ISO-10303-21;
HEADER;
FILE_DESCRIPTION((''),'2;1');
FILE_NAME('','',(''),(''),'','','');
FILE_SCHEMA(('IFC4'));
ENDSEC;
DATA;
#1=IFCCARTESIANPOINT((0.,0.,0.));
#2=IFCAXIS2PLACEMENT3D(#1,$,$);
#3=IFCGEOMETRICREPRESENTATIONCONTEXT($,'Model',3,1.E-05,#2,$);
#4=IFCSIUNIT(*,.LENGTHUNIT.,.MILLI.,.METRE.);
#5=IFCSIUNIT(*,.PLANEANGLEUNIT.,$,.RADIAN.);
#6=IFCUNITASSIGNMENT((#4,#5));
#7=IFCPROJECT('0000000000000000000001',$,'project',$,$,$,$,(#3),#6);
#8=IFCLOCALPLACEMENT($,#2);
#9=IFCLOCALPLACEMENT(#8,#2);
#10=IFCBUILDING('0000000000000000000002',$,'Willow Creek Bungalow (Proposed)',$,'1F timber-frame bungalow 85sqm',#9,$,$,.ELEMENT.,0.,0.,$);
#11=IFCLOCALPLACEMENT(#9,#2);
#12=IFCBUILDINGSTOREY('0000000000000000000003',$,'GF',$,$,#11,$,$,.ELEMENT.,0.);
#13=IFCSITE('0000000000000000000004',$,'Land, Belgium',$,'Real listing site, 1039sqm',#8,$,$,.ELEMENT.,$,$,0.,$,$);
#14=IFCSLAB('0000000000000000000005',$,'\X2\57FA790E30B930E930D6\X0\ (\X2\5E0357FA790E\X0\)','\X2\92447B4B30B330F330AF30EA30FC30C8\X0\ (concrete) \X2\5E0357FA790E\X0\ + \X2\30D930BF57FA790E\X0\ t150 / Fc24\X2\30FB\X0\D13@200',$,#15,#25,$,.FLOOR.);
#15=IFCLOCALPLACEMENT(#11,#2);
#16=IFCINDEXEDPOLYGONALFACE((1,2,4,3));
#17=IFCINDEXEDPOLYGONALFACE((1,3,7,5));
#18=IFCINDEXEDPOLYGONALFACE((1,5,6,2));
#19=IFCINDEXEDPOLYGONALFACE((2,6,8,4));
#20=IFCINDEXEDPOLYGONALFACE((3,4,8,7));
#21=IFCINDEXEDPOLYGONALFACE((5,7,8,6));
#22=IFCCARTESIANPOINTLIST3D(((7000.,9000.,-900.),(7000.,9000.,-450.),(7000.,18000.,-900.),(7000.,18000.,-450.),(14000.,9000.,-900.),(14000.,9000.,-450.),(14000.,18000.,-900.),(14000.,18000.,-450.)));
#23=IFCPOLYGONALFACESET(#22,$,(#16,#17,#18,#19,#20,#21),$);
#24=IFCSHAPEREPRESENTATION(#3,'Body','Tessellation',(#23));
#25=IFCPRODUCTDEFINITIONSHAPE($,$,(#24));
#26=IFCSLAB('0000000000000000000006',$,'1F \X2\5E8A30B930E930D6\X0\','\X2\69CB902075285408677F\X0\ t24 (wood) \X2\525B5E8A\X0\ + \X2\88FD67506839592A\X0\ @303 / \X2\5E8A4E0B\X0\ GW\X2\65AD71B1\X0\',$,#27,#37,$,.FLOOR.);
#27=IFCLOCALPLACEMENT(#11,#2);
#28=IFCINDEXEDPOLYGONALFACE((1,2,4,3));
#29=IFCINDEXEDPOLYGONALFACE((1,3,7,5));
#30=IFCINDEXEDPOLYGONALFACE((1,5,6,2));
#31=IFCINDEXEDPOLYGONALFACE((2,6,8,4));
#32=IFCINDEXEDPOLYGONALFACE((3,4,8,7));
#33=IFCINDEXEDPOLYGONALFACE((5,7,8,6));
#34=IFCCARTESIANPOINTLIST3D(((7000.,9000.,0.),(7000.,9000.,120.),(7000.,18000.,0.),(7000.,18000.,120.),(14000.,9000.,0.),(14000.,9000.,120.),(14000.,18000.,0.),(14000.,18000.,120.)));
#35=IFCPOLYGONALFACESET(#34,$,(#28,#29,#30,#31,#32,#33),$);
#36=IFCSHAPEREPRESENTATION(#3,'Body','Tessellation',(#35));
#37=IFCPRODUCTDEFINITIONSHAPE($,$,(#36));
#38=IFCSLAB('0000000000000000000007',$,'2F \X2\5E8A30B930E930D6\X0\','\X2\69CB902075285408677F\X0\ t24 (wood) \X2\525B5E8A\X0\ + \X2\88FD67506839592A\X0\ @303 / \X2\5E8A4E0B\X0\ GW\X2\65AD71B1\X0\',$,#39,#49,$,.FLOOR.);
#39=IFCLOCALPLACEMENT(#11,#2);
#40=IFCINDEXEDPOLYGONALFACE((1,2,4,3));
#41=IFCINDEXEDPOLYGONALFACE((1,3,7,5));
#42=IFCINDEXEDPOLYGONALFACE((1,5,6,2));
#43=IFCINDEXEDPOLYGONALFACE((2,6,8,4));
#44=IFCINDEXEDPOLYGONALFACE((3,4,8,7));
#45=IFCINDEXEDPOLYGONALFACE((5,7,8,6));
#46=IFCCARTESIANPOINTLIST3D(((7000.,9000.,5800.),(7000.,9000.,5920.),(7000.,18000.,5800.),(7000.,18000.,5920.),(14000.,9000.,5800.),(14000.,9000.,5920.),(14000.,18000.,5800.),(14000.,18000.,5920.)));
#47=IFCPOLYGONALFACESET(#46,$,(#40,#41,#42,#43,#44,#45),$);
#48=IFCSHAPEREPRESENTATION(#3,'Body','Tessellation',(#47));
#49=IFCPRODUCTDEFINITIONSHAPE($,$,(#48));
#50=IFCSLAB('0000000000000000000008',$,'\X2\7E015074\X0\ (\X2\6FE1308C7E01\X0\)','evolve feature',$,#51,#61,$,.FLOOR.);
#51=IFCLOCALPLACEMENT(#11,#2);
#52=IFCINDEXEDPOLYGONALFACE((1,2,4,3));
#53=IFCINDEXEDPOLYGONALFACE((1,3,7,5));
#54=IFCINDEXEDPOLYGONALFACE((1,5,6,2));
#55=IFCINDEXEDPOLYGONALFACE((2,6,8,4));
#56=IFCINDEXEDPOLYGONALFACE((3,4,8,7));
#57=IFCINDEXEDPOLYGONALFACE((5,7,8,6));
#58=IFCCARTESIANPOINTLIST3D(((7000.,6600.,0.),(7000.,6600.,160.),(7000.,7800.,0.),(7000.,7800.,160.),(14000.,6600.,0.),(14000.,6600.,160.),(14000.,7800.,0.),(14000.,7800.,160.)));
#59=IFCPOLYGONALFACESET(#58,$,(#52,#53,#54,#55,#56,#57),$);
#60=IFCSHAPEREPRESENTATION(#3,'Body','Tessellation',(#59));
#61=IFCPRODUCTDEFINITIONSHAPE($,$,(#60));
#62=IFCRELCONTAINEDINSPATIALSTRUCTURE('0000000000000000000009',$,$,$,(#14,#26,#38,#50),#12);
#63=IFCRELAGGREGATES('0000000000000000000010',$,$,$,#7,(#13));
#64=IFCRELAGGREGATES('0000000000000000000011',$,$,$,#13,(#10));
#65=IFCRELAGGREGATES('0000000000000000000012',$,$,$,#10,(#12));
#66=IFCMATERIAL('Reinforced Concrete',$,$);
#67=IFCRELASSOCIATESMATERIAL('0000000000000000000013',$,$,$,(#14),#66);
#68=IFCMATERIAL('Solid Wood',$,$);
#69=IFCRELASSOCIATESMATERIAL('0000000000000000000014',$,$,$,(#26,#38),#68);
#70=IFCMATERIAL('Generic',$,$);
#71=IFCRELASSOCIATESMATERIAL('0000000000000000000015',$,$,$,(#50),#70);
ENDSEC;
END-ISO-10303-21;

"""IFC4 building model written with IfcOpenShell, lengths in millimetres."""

from ifc_helpers import new_model, si_unit, frame, frame_2d, origin, place, context, project, spatial, rectangle, extrude, material, element, save


model = new_model("IFC4")

# Units and contexts
model_context = context("Model", 3, precision=1e-05, world=origin())
ifc_project = project(units=[si_unit("LENGTHUNIT", "METRE", prefix="MILLI"), si_unit("PLANEANGLEUNIT", "RADIAN")], contexts=[model_context])

# Site, building, storey
site_placement = place(None, origin())
site = spatial("IfcSite", under=ifc_project, at=site_placement, Name="Land, Belgium", ObjectType="Real listing site, 1039sqm", CompositionType="ELEMENT", RefElevation=0.0)
building_placement = place(site_placement, origin())
building = spatial("IfcBuilding", under=site, at=building_placement, Name="Willow Creek Bungalow (Proposed)", ObjectType="1F timber-frame bungalow 85sqm", CompositionType="ELEMENT", ElevationOfRefHeight=0.0, ElevationOfTerrain=0.0)
storey_placement = place(building_placement, origin())
storey = spatial("IfcBuildingStorey", under=building, at=storey_placement, Name="GF", CompositionType="ELEMENT", Elevation=0.0)

# Slabs
ifc_material_1 = material(Name="Reinforced Concrete")
slab_1_placement = place(storey_placement, frame((3500.0, 4500.0, -450.0)))
element("IfcSlab", 1, at=slab_1_placement, inside=storey, material=ifc_material_1, Name="基礎スラブ (布基礎)", Description="鉄筋コンクリート (concrete) 布基礎 + ベタ基礎 t150 / Fc24・D13@200", PredefinedType="FLOOR", context=model_context, shape_type="SweptSolid", body=[
    extrude(rectangle(XDim=7000.0, YDim=9000.0, at=frame_2d((3500.0, 4500.0))), frame((3500.0, 4500.0, -450.0)), (0.0, 0.0, 1.0), 450.0),
])
ifc_material_2 = material(Name="Solid Wood")
slab_2_placement = place(storey_placement, frame((3500.0, 4500.0, 0.0)))
element("IfcSlab", 2, at=slab_2_placement, inside=storey, material=ifc_material_2, Name="1F 床スラブ", Description="構造用合板 t24 (wood) 剛床 + 製材根太 @303 / 床下 GW断熱", PredefinedType="FLOOR", context=model_context, shape_type="SweptSolid", body=[
    extrude(rectangle(XDim=7000.0, YDim=9000.0, at=frame_2d((3500.0, 4500.0))), frame((3500.0, 4500.0, 0.0)), (0.0, 0.0, 1.0), 120.0),
])
slab_3_placement = place(storey_placement, frame((3500.0, 4500.0, 2900.0)))
element("IfcSlab", 3, at=slab_3_placement, inside=storey, material=ifc_material_2, Name="2F 床スラブ", Description="構造用合板 t24 (wood) 剛床 + 製材根太 @303 / 床下 GW断熱", PredefinedType="FLOOR", context=model_context, shape_type="SweptSolid", body=[
    extrude(rectangle(XDim=7000.0, YDim=9000.0, at=frame_2d((3500.0, 4500.0))), frame((3500.0, 4500.0, 2900.0)), (0.0, 0.0, 1.0), 120.0),
])
ifc_material_3 = material(Name="Generic")
slab_4_placement = place(storey_placement, frame((3500.0, 3300.0, 0.0)))
element("IfcSlab", 4, at=slab_4_placement, inside=storey, material=ifc_material_3, Name="縁側 (濡れ縁)", Description="evolve feature", PredefinedType="FLOOR", context=model_context, shape_type="SweptSolid", body=[
    extrude(rectangle(XDim=7000.0, YDim=1200.0, at=frame_2d((3500.0, 600.0))), frame((3500.0, 3300.0, 0.0)), (0.0, 0.0, 1.0), 160.0),
])

save(model, "model.ifc")
